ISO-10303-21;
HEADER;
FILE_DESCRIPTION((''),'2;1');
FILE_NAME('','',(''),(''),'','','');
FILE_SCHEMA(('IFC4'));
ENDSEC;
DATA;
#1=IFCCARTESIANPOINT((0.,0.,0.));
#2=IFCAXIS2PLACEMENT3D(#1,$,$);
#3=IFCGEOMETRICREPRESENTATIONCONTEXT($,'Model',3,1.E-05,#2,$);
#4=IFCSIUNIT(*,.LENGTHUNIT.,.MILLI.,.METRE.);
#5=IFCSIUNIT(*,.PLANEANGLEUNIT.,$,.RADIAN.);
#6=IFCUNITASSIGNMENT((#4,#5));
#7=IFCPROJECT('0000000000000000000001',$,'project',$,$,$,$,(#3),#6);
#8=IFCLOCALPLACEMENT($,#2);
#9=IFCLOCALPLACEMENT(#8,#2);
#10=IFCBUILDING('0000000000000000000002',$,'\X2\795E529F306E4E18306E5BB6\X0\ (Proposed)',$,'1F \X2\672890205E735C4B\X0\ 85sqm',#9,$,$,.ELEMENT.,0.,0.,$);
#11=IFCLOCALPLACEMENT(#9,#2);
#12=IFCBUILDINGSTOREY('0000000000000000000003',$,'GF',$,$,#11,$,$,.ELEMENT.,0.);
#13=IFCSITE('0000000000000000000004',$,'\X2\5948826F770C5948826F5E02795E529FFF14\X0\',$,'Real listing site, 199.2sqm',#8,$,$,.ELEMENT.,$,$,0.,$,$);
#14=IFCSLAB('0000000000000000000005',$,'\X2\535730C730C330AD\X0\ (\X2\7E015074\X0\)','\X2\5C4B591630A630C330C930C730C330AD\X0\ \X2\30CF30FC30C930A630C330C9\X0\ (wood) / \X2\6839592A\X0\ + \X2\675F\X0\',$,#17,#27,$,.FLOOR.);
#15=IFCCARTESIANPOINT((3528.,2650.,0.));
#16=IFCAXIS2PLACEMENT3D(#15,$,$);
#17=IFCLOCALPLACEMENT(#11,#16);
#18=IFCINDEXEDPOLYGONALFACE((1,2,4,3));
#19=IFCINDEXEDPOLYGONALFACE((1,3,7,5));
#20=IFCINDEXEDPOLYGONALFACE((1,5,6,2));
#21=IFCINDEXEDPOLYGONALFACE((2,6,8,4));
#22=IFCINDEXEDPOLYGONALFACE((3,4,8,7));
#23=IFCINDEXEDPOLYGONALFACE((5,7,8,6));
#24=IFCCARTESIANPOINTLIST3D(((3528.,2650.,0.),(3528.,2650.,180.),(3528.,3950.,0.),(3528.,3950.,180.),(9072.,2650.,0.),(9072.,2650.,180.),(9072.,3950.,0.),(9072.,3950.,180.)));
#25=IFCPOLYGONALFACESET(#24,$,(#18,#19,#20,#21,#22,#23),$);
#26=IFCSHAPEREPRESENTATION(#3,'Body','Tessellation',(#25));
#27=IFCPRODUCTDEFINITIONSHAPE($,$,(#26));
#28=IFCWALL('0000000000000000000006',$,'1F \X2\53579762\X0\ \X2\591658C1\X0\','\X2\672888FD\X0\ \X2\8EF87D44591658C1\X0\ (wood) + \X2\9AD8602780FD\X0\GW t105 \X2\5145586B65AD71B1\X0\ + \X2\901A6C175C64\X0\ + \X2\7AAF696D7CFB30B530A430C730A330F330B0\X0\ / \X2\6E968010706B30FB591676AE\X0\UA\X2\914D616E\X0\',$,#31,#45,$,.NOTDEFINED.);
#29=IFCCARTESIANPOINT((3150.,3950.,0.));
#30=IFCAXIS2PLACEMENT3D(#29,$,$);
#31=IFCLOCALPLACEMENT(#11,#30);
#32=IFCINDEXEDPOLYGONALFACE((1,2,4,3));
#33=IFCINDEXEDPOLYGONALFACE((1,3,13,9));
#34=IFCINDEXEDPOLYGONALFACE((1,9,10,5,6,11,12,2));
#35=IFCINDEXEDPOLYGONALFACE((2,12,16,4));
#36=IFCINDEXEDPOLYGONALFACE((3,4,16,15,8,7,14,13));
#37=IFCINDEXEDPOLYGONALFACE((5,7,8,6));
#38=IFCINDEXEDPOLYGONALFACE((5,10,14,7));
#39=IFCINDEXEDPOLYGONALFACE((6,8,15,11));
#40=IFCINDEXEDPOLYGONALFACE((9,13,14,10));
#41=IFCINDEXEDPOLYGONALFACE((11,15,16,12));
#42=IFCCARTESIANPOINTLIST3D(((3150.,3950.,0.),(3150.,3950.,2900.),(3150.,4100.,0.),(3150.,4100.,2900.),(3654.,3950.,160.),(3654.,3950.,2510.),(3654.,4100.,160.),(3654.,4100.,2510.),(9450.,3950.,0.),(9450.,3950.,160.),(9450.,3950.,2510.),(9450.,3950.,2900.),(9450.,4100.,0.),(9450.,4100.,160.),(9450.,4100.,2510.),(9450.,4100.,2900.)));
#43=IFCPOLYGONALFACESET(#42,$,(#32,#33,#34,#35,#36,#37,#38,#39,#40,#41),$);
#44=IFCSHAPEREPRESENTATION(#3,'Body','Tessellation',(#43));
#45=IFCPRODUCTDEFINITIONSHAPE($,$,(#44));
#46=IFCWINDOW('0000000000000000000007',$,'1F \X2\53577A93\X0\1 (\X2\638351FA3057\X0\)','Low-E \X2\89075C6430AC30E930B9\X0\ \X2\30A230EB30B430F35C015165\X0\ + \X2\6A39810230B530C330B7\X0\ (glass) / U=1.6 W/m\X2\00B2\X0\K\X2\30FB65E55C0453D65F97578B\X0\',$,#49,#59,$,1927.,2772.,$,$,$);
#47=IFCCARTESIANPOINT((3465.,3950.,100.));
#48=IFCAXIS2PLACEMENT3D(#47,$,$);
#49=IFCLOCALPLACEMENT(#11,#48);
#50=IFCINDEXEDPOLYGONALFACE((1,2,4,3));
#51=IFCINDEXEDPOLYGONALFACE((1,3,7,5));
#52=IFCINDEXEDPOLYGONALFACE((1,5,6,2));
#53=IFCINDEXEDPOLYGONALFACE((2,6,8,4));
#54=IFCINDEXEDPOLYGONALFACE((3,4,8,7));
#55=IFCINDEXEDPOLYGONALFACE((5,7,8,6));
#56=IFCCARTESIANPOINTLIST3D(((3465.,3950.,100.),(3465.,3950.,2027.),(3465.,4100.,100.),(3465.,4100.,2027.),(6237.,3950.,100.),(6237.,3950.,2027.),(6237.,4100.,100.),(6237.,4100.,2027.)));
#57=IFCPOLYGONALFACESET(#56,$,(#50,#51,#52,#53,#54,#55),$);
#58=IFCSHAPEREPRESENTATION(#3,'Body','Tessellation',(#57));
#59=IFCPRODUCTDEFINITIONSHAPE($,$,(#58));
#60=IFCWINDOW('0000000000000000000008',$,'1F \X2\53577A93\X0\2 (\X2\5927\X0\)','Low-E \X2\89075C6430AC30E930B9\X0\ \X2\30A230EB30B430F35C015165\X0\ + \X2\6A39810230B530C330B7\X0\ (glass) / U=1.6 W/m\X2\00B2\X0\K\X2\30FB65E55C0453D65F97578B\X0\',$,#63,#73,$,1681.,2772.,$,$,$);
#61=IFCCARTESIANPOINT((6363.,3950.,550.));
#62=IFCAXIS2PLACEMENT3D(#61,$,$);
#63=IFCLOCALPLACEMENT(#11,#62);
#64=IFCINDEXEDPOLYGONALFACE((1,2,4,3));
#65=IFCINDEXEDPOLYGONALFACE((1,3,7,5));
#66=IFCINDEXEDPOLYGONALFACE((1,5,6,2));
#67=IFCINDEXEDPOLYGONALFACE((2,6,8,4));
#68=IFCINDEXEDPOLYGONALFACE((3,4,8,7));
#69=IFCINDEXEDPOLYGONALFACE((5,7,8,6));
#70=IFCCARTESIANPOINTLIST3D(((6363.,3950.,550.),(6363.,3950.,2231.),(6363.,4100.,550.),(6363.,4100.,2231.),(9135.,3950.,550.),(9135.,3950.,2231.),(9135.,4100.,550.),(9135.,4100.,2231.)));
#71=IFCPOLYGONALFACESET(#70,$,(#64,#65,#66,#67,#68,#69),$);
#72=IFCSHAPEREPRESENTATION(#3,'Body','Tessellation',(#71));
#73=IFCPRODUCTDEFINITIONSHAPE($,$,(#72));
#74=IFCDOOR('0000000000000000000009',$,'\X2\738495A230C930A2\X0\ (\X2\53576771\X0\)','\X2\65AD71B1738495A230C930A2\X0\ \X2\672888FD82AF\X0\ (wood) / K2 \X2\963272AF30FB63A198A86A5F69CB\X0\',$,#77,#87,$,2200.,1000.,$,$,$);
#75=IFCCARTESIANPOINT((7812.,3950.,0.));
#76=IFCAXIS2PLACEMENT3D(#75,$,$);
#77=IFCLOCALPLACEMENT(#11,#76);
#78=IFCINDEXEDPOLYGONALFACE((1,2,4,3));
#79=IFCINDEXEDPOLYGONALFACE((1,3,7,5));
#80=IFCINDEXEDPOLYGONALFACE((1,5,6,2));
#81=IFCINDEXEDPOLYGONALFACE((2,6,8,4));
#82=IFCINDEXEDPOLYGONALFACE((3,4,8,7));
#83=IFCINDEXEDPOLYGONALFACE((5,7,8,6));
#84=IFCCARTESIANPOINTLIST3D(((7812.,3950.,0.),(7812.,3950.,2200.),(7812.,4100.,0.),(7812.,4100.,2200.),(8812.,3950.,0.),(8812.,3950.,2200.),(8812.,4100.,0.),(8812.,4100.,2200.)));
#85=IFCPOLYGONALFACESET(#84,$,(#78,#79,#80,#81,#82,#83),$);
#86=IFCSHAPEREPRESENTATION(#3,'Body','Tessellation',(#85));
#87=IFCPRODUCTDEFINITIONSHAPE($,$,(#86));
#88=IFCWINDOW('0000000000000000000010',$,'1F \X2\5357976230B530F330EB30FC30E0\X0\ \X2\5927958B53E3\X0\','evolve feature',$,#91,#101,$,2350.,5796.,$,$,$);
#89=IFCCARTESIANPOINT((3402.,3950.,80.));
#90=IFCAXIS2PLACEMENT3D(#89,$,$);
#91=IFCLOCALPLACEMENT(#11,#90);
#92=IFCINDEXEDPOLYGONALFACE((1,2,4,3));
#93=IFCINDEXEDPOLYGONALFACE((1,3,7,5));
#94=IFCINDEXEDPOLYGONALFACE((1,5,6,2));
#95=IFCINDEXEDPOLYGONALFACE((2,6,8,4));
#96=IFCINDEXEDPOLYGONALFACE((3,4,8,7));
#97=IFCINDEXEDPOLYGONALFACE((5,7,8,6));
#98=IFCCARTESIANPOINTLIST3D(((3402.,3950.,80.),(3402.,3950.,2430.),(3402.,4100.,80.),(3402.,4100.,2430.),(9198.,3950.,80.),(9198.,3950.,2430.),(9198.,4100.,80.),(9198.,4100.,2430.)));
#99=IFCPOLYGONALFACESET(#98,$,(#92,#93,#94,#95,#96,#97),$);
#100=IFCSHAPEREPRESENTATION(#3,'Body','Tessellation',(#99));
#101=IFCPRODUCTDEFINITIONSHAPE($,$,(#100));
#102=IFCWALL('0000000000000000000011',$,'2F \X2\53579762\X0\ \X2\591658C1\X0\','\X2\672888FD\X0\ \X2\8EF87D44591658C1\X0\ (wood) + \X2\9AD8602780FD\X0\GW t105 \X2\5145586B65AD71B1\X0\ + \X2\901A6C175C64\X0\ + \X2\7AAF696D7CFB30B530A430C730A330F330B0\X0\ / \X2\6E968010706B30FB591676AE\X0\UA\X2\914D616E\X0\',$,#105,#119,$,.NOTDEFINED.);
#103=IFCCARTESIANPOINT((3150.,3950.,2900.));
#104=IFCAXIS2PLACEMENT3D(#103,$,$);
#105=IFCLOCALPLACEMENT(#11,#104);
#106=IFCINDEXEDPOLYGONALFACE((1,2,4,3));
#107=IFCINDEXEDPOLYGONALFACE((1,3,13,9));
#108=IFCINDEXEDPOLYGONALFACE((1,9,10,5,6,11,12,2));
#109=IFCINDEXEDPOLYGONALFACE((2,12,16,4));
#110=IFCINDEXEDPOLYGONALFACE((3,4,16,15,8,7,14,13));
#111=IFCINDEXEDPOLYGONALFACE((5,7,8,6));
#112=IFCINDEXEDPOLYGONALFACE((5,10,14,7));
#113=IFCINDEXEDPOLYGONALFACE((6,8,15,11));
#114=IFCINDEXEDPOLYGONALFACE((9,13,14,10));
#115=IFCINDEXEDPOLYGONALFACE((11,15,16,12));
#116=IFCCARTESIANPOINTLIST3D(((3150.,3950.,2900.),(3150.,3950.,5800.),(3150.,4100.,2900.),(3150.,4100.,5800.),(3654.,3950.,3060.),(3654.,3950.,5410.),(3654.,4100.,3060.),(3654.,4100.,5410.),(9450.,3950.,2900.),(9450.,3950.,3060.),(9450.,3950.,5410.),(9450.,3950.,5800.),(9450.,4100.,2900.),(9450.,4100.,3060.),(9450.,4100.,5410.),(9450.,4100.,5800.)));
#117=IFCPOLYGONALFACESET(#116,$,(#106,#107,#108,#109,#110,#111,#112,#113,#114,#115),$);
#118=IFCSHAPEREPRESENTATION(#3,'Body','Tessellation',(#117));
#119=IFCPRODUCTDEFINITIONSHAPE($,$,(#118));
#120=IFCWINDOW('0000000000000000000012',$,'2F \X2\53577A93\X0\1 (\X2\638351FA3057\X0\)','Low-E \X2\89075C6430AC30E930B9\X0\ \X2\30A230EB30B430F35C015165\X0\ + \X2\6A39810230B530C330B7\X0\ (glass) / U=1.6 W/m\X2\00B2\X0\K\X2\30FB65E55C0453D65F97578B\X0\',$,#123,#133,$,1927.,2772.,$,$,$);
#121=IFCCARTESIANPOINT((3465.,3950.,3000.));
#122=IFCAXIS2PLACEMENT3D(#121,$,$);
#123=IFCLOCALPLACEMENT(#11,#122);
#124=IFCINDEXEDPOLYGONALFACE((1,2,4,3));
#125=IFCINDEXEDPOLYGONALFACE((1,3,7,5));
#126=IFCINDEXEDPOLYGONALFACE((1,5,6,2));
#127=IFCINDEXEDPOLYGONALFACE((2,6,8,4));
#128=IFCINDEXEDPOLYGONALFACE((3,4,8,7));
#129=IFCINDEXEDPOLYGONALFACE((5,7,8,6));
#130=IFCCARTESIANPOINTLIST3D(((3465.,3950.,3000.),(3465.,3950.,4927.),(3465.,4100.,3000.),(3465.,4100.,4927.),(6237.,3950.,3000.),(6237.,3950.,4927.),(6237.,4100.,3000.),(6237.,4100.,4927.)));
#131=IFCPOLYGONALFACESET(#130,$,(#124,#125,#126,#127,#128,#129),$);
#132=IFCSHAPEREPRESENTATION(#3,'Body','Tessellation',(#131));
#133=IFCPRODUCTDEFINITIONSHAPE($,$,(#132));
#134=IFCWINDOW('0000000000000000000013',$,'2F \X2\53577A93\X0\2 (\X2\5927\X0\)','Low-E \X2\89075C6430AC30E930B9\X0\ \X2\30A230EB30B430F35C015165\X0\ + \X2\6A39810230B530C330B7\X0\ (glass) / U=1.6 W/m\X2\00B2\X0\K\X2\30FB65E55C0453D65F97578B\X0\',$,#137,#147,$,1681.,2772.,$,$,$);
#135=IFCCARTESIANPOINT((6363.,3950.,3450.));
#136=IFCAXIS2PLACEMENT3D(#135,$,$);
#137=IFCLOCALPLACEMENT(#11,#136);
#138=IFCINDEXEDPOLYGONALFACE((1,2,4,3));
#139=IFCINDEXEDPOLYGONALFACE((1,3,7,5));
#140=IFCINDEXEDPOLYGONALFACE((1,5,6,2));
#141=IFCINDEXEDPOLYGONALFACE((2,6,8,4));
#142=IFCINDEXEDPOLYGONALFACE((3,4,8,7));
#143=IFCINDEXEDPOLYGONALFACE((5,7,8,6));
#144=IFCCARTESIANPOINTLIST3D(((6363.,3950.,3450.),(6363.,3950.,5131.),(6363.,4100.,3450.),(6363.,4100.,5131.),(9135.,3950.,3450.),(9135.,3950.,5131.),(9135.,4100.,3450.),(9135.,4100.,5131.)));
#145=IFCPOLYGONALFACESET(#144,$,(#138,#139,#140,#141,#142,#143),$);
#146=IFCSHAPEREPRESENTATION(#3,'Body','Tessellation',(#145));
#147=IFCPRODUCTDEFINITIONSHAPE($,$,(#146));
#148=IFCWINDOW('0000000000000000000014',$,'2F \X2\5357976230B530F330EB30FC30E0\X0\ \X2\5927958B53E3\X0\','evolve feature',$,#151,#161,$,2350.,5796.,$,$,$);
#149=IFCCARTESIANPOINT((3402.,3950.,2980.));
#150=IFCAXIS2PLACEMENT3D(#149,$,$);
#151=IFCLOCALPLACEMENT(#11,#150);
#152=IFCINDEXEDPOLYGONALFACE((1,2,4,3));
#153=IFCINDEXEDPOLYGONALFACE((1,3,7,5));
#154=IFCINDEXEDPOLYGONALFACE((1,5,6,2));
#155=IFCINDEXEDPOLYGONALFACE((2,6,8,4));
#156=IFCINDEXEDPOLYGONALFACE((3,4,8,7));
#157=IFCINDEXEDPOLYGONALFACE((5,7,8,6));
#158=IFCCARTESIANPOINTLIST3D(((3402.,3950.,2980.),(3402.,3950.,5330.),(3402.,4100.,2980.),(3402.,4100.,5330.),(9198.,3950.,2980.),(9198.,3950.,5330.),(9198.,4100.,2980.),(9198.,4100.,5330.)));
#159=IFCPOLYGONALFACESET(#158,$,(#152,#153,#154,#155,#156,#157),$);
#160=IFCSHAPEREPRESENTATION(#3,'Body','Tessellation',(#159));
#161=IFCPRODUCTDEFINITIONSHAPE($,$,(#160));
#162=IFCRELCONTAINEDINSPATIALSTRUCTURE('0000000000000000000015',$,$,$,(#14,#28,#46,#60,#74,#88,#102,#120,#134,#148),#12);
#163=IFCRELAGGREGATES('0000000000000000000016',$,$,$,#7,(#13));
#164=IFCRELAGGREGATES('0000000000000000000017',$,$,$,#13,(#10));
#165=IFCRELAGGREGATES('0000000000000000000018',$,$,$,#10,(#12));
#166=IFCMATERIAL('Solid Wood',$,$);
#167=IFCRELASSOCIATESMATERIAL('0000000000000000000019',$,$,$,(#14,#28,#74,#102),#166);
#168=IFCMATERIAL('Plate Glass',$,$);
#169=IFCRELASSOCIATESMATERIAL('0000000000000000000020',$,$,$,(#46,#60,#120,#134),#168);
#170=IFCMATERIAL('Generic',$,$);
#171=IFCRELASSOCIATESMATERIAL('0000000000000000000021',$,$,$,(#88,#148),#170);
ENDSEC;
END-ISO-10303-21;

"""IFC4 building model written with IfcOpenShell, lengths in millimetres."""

from ifc_helpers import new_model, si_unit, frame, frame_2d, origin, place, context, project, spatial, rectangle, extrude, material, element, fill, save


model = new_model("IFC4")

# Units and contexts
model_context = context("Model", 3, precision=1e-05, world=origin())
ifc_project = project(units=[si_unit("LENGTHUNIT", "METRE", prefix="MILLI"), si_unit("PLANEANGLEUNIT", "RADIAN")], contexts=[model_context])

# Site, building, storey
site_placement = place(None, origin())
site = spatial("IfcSite", under=ifc_project, at=site_placement, Name="奈良県奈良市神功４", ObjectType="Real listing site, 199.2sqm", CompositionType="ELEMENT", RefElevation=0.0)
building_placement = place(site_placement, origin())
building = spatial("IfcBuilding", under=site, at=building_placement, Name="神功の丘の家 (Proposed)", ObjectType="1F 木造平屋 85sqm", CompositionType="ELEMENT", ElevationOfRefHeight=0.0, ElevationOfTerrain=0.0)
storey_placement = place(building_placement, origin())
storey = spatial("IfcBuildingStorey", under=building, at=storey_placement, Name="GF", CompositionType="ELEMENT", Elevation=0.0)

# Slab
ifc_material_1 = material(Name="Solid Wood")
slab_1_placement = place(storey_placement, frame((3528.0, 2650.0, 0.0)))
element("IfcSlab", 1, at=slab_1_placement, inside=storey, material=ifc_material_1, Name="南デッキ (縁側)", Description="屋外ウッドデッキ ハードウッド (wood) / 根太 + 束", PredefinedType="FLOOR", context=model_context, shape_type="SweptSolid", body=[
    extrude(rectangle(XDim=5544.0, YDim=1300.0, at=frame_2d((2772.0, 650.0))), frame((3528.0, 2650.0, 0.0)), (0.0, 0.0, 1.0), 180.0),
])
ifc_material_2 = material(Name="Generic")

# Wall, openings, windows, door
wall_1_placement = place(storey_placement, frame((3150.0, 3950.0, 0.0)))
wall_1 = element("IfcWall", 2, at=wall_1_placement, inside=storey, material=ifc_material_1, Name="1F 南面 外壁", Description="木製 軸組外壁 (wood) + 高性能GW t105 充填断熱 + 通気層 + 窯業系サイディング / 準耐火・外皮UA配慮", PredefinedType="NOTDEFINED", context=model_context, shape_type="SweptSolid", body=[
    extrude(rectangle(XDim=6300.0, YDim=150.0, at=frame_2d((3150.0, 75.0))), frame((3150.0, 3950.0, 0.0)), (0.0, 0.0, 1.0), 2900.0),
])
opening_1_placement = place(storey_placement, frame((3465.0, 3950.0, 100.0)))
opening_1 = element("IfcOpeningElement", 3, at=opening_1_placement, cuts=wall_1, PredefinedType="NOTDEFINED", context=model_context, shape_type="SweptSolid", body=[
    extrude(rectangle(XDim=2772.0, YDim=150.0, at=frame_2d((1386.0, 75.0))), frame((3465.0, 3950.0, 100.0)), (0.0, 0.0, 1.0), 1927.0),
])
opening_2_placement = place(storey_placement, frame((6363.0, 3950.0, 550.0)))
opening_2 = element("IfcOpeningElement", 4, at=opening_2_placement, cuts=wall_1, PredefinedType="NOTDEFINED", context=model_context, shape_type="SweptSolid", body=[
    extrude(rectangle(XDim=2772.0, YDim=150.0, at=frame_2d((1386.0, 75.0))), frame((6363.0, 3950.0, 550.0)), (0.0, 0.0, 1.0), 1681.0),
])
opening_3_placement = place(storey_placement, frame((7812.0, 3950.0, 0.0)))
opening_3 = element("IfcOpeningElement", 5, at=opening_3_placement, cuts=wall_1, PredefinedType="NOTDEFINED", context=model_context, shape_type="SweptSolid", body=[
    extrude(rectangle(XDim=1000.0, YDim=150.0, at=frame_2d((500.0, 75.0))), frame((7812.0, 3950.0, 0.0)), (0.0, 0.0, 1.0), 2200.0),
])
opening_4_placement = place(storey_placement, frame((3402.0, 3950.0, 80.0)))
opening_4 = element("IfcOpeningElement", 6, at=opening_4_placement, cuts=wall_1, PredefinedType="NOTDEFINED", context=model_context, shape_type="SweptSolid", body=[
    extrude(rectangle(XDim=5796.0, YDim=150.0, at=frame_2d((2898.0, 75.0))), frame((3402.0, 3950.0, 80.0)), (0.0, 0.0, 1.0), 2350.0),
])
ifc_material_3 = material(Name="Plate Glass")
window_1_placement = place(storey_placement, frame((3465.0, 3950.0, 100.0)))
window_1 = element("IfcWindow", 7, at=window_1_placement, inside=storey, material=ifc_material_3, Name="1F 南窓1 (掃出し)", Description="Low-E 複層ガラス アルゴン封入 + 樹脂サッシ (glass) / U=1.6 W/m²K・日射取得型", OverallHeight=1927.0, OverallWidth=2772.0, context=model_context, shape_type="SweptSolid", body=[
    extrude(rectangle(XDim=2772.0, YDim=150.0, at=frame_2d((1386.0, 75.0))), frame((3465.0, 3950.0, 100.0)), (0.0, 0.0, 1.0), 1927.0),
])
fill(opening_1, window_1)
window_2_placement = place(storey_placement, frame((6363.0, 3950.0, 550.0)))
window_2 = element("IfcWindow", 8, at=window_2_placement, inside=storey, material=ifc_material_3, Name="1F 南窓2 (大)", Description="Low-E 複層ガラス アルゴン封入 + 樹脂サッシ (glass) / U=1.6 W/m²K・日射取得型", OverallHeight=1681.0, OverallWidth=2772.0, context=model_context, shape_type="SweptSolid", body=[
    extrude(rectangle(XDim=2772.0, YDim=150.0, at=frame_2d((1386.0, 75.0))), frame((6363.0, 3950.0, 550.0)), (0.0, 0.0, 1.0), 1681.0),
])
fill(opening_2, window_2)
door_placement = place(storey_placement, frame((7812.0, 3950.0, 0.0)))
door = element("IfcDoor", 9, at=door_placement, inside=storey, material=ifc_material_1, Name="玄関ドア (南東)", Description="断熱玄関ドア 木製芯 (wood) / K2 防犯・採風機構", OverallHeight=2200.0, OverallWidth=1000.0, context=model_context, shape_type="SweptSolid", body=[
    extrude(rectangle(XDim=1000.0, YDim=150.0, at=frame_2d((500.0, 75.0))), frame((7812.0, 3950.0, 0.0)), (0.0, 0.0, 1.0), 2200.0),
])
fill(opening_3, door)
window_3_placement = place(storey_placement, frame((3402.0, 3950.0, 80.0)))
window_3 = element("IfcWindow", 10, at=window_3_placement, inside=storey, material=ifc_material_2, Name="1F 南面サンルーム 大開口", Description="evolve feature", OverallHeight=2350.0, OverallWidth=5796.0, context=model_context, shape_type="SweptSolid", body=[
    extrude(rectangle(XDim=5796.0, YDim=150.0, at=frame_2d((2898.0, 75.0))), frame((3402.0, 3950.0, 80.0)), (0.0, 0.0, 1.0), 2350.0),
])
fill(opening_4, window_3)

# Wall, openings, windows
wall_2_placement = place(storey_placement, frame((3150.0, 3950.0, 2900.0)))
wall_2 = element("IfcWall", 11, at=wall_2_placement, inside=storey, material=ifc_material_1, Name="2F 南面 外壁", Description="木製 軸組外壁 (wood) + 高性能GW t105 充填断熱 + 通気層 + 窯業系サイディング / 準耐火・外皮UA配慮", PredefinedType="NOTDEFINED", context=model_context, shape_type="SweptSolid", body=[
    extrude(rectangle(XDim=6300.0, YDim=150.0, at=frame_2d((3150.0, 75.0))), frame((3150.0, 3950.0, 2900.0)), (0.0, 0.0, 1.0), 2900.0),
])
opening_5_placement = place(storey_placement, frame((3465.0, 3950.0, 3000.0)))
opening_5 = element("IfcOpeningElement", 12, at=opening_5_placement, cuts=wall_2, PredefinedType="NOTDEFINED", context=model_context, shape_type="SweptSolid", body=[
    extrude(rectangle(XDim=2772.0, YDim=150.0, at=frame_2d((1386.0, 75.0))), frame((3465.0, 3950.0, 3000.0)), (0.0, 0.0, 1.0), 1927.0),
])
opening_6_placement = place(storey_placement, frame((6363.0, 3950.0, 3450.0)))
opening_6 = element("IfcOpeningElement", 13, at=opening_6_placement, cuts=wall_2, PredefinedType="NOTDEFINED", context=model_context, shape_type="SweptSolid", body=[
    extrude(rectangle(XDim=2772.0, YDim=150.0, at=frame_2d((1386.0, 75.0))), frame((6363.0, 3950.0, 3450.0)), (0.0, 0.0, 1.0), 1681.0),
])
opening_7_placement = place(storey_placement, frame((3402.0, 3950.0, 2980.0)))
opening_7 = element("IfcOpeningElement", 14, at=opening_7_placement, cuts=wall_2, PredefinedType="NOTDEFINED", context=model_context, shape_type="SweptSolid", body=[
    extrude(rectangle(XDim=5796.0, YDim=150.0, at=frame_2d((2898.0, 75.0))), frame((3402.0, 3950.0, 2980.0)), (0.0, 0.0, 1.0), 2350.0),
])
window_4_placement = place(storey_placement, frame((3465.0, 3950.0, 3000.0)))
window_4 = element("IfcWindow", 15, at=window_4_placement, inside=storey, material=ifc_material_3, Name="2F 南窓1 (掃出し)", Description="Low-E 複層ガラス アルゴン封入 + 樹脂サッシ (glass) / U=1.6 W/m²K・日射取得型", OverallHeight=1927.0, OverallWidth=2772.0, context=model_context, shape_type="SweptSolid", body=[
    extrude(rectangle(XDim=2772.0, YDim=150.0, at=frame_2d((1386.0, 75.0))), frame((3465.0, 3950.0, 3000.0)), (0.0, 0.0, 1.0), 1927.0),
])
fill(opening_5, window_4)
window_5_placement = place(storey_placement, frame((6363.0, 3950.0, 3450.0)))
window_5 = element("IfcWindow", 16, at=window_5_placement, inside=storey, material=ifc_material_3, Name="2F 南窓2 (大)", Description="Low-E 複層ガラス アルゴン封入 + 樹脂サッシ (glass) / U=1.6 W/m²K・日射取得型", OverallHeight=1681.0, OverallWidth=2772.0, context=model_context, shape_type="SweptSolid", body=[
    extrude(rectangle(XDim=2772.0, YDim=150.0, at=frame_2d((1386.0, 75.0))), frame((6363.0, 3950.0, 3450.0)), (0.0, 0.0, 1.0), 1681.0),
])
fill(opening_6, window_5)
window_6_placement = place(storey_placement, frame((3402.0, 3950.0, 2980.0)))
window_6 = element("IfcWindow", 17, at=window_6_placement, inside=storey, material=ifc_material_2, Name="2F 南面サンルーム 大開口", Description="evolve feature", OverallHeight=2350.0, OverallWidth=5796.0, context=model_context, shape_type="SweptSolid", body=[
    extrude(rectangle(XDim=5796.0, YDim=150.0, at=frame_2d((2898.0, 75.0))), frame((3402.0, 3950.0, 2980.0)), (0.0, 0.0, 1.0), 2350.0),
])
fill(opening_7, window_6)

save(model, "model.ifc")
